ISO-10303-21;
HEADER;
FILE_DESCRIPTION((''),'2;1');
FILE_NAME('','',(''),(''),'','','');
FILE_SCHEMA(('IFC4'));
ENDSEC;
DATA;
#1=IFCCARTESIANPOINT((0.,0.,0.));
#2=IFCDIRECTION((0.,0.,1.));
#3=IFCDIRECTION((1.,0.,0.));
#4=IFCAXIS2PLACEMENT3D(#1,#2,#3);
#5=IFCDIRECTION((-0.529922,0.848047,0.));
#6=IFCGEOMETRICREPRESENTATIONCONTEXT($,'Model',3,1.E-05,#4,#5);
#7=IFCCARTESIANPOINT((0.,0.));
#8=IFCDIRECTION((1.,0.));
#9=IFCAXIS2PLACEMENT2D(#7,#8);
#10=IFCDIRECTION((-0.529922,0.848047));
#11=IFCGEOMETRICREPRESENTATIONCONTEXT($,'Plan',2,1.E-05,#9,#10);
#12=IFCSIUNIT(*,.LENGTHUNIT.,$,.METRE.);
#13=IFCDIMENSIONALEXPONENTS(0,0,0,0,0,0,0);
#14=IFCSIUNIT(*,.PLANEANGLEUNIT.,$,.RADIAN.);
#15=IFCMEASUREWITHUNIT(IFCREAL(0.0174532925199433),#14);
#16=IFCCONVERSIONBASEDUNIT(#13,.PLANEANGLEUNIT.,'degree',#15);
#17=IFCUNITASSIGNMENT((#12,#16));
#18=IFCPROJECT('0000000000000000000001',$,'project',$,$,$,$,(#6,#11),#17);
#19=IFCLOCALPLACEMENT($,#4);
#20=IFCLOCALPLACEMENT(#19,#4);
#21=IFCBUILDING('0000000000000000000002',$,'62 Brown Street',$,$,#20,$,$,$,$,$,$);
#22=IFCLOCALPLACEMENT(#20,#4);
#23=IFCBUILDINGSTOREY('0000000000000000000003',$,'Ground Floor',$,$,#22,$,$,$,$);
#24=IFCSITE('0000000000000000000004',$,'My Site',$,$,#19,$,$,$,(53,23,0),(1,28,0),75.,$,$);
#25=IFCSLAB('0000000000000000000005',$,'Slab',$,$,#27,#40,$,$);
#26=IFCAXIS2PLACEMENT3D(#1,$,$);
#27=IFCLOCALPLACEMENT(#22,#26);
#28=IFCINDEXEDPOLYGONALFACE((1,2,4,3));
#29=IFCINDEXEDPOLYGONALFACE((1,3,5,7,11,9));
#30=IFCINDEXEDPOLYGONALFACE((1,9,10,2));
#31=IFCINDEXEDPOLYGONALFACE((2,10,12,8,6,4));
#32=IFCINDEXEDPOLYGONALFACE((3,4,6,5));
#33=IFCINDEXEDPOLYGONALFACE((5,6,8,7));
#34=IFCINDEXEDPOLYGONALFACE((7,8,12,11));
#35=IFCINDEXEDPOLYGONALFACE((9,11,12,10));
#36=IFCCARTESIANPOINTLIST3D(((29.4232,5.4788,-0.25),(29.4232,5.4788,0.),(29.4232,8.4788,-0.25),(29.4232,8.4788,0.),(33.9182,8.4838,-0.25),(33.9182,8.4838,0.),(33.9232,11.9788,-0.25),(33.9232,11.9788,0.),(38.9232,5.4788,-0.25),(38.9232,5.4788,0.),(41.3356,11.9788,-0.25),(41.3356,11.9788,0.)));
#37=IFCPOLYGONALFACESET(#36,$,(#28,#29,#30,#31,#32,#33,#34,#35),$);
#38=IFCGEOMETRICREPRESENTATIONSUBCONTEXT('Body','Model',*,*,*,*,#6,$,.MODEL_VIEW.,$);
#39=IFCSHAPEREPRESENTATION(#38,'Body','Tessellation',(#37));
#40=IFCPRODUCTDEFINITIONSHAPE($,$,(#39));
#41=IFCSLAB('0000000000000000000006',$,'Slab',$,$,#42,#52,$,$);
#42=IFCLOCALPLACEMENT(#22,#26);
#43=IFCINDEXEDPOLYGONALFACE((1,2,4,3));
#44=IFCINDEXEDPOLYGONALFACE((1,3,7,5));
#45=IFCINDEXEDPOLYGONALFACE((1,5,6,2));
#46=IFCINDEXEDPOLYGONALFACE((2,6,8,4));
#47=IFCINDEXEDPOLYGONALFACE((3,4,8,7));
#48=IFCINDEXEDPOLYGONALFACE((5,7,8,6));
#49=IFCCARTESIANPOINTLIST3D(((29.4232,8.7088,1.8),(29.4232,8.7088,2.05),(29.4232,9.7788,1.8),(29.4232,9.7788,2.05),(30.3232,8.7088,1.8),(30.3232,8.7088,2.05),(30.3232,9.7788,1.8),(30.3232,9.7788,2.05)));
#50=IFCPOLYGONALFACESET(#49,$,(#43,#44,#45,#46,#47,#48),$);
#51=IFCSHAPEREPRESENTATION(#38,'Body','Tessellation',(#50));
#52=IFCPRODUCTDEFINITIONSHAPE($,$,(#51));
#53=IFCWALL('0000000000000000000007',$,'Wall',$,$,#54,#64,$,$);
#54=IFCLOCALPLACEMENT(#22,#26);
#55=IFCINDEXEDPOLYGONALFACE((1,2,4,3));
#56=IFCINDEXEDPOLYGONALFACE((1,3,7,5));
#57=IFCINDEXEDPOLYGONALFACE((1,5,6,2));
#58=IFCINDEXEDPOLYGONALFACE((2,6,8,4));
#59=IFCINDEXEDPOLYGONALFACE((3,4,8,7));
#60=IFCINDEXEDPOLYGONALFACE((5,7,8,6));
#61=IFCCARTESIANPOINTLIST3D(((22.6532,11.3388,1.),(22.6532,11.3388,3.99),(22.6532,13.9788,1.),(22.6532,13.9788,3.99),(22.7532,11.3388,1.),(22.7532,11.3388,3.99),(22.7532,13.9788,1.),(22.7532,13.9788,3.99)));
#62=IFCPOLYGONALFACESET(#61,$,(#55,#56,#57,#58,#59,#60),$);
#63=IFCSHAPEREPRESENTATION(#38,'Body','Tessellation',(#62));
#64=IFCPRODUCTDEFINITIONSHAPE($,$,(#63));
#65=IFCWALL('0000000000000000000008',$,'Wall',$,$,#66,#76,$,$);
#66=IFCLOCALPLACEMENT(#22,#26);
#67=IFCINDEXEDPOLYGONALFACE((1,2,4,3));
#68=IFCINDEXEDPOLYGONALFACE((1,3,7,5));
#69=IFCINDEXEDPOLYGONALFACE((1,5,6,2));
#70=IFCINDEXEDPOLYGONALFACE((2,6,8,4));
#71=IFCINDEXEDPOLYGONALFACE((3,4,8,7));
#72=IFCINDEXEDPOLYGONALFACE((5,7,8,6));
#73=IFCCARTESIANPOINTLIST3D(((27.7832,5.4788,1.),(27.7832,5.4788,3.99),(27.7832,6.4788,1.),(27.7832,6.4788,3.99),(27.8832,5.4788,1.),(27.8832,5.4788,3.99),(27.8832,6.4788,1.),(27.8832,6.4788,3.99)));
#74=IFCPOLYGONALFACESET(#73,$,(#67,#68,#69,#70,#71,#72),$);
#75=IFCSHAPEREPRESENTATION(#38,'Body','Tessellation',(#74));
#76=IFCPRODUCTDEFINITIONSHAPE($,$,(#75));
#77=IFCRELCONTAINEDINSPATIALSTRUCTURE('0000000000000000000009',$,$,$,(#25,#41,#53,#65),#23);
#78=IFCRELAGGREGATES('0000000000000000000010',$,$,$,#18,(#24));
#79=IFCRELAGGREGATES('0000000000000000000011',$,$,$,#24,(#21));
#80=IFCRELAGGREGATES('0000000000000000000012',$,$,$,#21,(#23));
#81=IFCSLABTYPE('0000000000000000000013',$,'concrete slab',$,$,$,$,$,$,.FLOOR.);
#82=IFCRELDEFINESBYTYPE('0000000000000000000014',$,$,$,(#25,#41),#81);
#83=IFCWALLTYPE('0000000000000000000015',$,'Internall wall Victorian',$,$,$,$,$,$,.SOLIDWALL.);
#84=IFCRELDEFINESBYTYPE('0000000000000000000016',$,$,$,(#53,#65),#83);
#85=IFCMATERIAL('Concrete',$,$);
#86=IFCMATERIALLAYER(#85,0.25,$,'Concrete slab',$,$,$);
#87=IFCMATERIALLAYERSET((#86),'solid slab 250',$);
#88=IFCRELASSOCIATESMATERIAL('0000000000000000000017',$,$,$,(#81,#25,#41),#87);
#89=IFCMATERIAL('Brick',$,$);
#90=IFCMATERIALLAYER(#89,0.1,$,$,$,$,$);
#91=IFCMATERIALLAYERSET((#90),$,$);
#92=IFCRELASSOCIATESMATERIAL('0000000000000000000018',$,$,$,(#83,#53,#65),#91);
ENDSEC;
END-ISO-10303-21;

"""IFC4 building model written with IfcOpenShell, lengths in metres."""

from ifc_helpers import new_model, entity, si_unit, converted_unit, direction, frame, origin_with_axes, origin_2d_with_axis, place, context, subcontext, project, spatial, line, indexed_curve, outline, extrude, material, layer, layer_set, layer_usage, type_object, element, save


model = new_model("IFC4")

# Units and contexts
model_context = context("Model", 3, precision=1e-05, world=origin_with_axes(), true_north=direction((-0.529922, 0.848047, 0.0)))
plan_context = context("Plan", 2, precision=1e-05, world=origin_2d_with_axis(), true_north=direction((-0.529922, 0.848047)))
body_context = subcontext(model_context, "Body", "Model", "MODEL_VIEW")
ifc_project = project(units=[si_unit("LENGTHUNIT", "METRE"), converted_unit("PLANEANGLEUNIT", "degree", entity("IfcReal", 0.0174532925199433), si_unit("PLANEANGLEUNIT", "RADIAN"), dimensions=[0, 0, 0, 0, 0, 0, 0])], contexts=[model_context, plan_context])

# Site, building, storey
site_placement = place(None, origin_with_axes())
site = spatial("IfcSite", under=ifc_project, at=site_placement, Name="My Site", RefLatitude=(53, 23, 0), RefLongitude=(1, 28, 0), RefElevation=75.0)
building_placement = place(site_placement, origin_with_axes())
building = spatial("IfcBuilding", under=site, at=building_placement, Name="62 Brown Street")
storey_placement = place(building_placement, origin_with_axes())
storey = spatial("IfcBuildingStorey", under=building, at=storey_placement, Name="Ground Floor")

# Shared definitions
ifc_material_1 = material(Name="Concrete")

# Slabs
ifc_layer_1 = layer(ifc_material_1, 0.25, Name="Concrete slab")
ifc_layer_set_1 = layer_set([ifc_layer_1], Name="solid slab 250")
ifc_layer_usage_1 = layer_usage(ifc_layer_set_1, "AXIS3", "POSITIVE", 0.0)
slab_type = type_object("IfcSlabType", Name="concrete slab", PredefinedType="FLOOR", material=ifc_layer_set_1)
slab_1_placement = place(storey_placement, frame((29.4232, 5.4788, -0.25), z_axis=(0.0, 0.0, 1.0), x_axis=(1.0, 0.0, 0.0)))
element("IfcSlab", 1, at=slab_1_placement, inside=storey, type_object=slab_type, material=ifc_layer_usage_1, Name="Slab", context=body_context, shape_type="SweptSolid", body=[
    extrude(outline(indexed_curve([(0.0, 0.0), (9.5, 0.0), (11.9124, 6.5), (0.0, 3.0), (4.5, 6.5), (4.495, 3.005)], segments=[line(1, 2), line(2, 3), line(3, 5), line(5, 6), line(6, 4), line(4, 1)], self_intersect=False)), None, (0.0, 0.0, 1.0), 0.25),
])
ifc_layer_usage_2 = layer_usage(ifc_layer_set_1, "AXIS3", "POSITIVE", 0.0)
slab_2_placement = place(storey_placement, frame((29.4232, 8.7088, 1.8), z_axis=(0.0, 0.0, 1.0), x_axis=(1.0, 0.0, 0.0)))
element("IfcSlab", 2, at=slab_2_placement, inside=storey, type_object=slab_type, material=ifc_layer_usage_2, Name="Slab", context=body_context, shape_type="SweptSolid", body=[
    extrude(outline(indexed_curve([(0.9, 1.07), (0.9, 0.0), (0.0, 0.0), (0.0, 1.07)], segments=[line(3, 2), line(2, 1), line(1, 4), line(4, 3)], self_intersect=False)), None, (0.0, 0.0, 1.0), 0.25),
])

# Walls
ifc_material_2 = material(Name="Brick")
ifc_layer_2 = layer(ifc_material_2, 0.1)
ifc_layer_set_2 = layer_set([ifc_layer_2])
ifc_layer_usage_3 = layer_usage(ifc_layer_set_2, "AXIS2", "POSITIVE", 0.0)
wall_type_1 = type_object("IfcWallType", Name="Internall wall Victorian", PredefinedType="SOLIDWALL", material=ifc_layer_set_2)
wall_1_placement = place(storey_placement, frame((22.7532, 11.3388, 1.0), z_axis=(0.0, 0.0, 1.0), x_axis=(0.0, 1.0, 0.0)))
element("IfcWall", 3, at=wall_1_placement, inside=storey, type_object=wall_type_1, material=ifc_layer_usage_3, Name="Wall", context=body_context, shape_type="SweptSolid", body=[
    extrude(outline(indexed_curve([(0.0, 0.0), (0.0, 0.1), (2.64, 0.1), (2.64, 0.0), (0.0, 0.0)], self_intersect=False)), origin_with_axes(), (0.0, 0.0, 1.0), 2.99),
])
ifc_layer_usage_4 = layer_usage(ifc_layer_set_2, "AXIS2", "POSITIVE", 0.0)
wall_2_placement = place(storey_placement, frame((27.8832, 5.4788, 1.0), z_axis=(0.0, 0.0, 1.0), x_axis=(0.0, 1.0, 0.0)))
element("IfcWall", 4, at=wall_2_placement, inside=storey, type_object=wall_type_1, material=ifc_layer_usage_4, Name="Wall", context=body_context, shape_type="SweptSolid", body=[
    extrude(outline(indexed_curve([(0.0, 0.0), (0.0, 0.1), (1.0, 0.1), (1.0, 0.0), (0.0, 0.0)], self_intersect=False)), origin_with_axes(), (0.0, 0.0, 1.0), 2.99),
])

save(model, "model.ifc")
